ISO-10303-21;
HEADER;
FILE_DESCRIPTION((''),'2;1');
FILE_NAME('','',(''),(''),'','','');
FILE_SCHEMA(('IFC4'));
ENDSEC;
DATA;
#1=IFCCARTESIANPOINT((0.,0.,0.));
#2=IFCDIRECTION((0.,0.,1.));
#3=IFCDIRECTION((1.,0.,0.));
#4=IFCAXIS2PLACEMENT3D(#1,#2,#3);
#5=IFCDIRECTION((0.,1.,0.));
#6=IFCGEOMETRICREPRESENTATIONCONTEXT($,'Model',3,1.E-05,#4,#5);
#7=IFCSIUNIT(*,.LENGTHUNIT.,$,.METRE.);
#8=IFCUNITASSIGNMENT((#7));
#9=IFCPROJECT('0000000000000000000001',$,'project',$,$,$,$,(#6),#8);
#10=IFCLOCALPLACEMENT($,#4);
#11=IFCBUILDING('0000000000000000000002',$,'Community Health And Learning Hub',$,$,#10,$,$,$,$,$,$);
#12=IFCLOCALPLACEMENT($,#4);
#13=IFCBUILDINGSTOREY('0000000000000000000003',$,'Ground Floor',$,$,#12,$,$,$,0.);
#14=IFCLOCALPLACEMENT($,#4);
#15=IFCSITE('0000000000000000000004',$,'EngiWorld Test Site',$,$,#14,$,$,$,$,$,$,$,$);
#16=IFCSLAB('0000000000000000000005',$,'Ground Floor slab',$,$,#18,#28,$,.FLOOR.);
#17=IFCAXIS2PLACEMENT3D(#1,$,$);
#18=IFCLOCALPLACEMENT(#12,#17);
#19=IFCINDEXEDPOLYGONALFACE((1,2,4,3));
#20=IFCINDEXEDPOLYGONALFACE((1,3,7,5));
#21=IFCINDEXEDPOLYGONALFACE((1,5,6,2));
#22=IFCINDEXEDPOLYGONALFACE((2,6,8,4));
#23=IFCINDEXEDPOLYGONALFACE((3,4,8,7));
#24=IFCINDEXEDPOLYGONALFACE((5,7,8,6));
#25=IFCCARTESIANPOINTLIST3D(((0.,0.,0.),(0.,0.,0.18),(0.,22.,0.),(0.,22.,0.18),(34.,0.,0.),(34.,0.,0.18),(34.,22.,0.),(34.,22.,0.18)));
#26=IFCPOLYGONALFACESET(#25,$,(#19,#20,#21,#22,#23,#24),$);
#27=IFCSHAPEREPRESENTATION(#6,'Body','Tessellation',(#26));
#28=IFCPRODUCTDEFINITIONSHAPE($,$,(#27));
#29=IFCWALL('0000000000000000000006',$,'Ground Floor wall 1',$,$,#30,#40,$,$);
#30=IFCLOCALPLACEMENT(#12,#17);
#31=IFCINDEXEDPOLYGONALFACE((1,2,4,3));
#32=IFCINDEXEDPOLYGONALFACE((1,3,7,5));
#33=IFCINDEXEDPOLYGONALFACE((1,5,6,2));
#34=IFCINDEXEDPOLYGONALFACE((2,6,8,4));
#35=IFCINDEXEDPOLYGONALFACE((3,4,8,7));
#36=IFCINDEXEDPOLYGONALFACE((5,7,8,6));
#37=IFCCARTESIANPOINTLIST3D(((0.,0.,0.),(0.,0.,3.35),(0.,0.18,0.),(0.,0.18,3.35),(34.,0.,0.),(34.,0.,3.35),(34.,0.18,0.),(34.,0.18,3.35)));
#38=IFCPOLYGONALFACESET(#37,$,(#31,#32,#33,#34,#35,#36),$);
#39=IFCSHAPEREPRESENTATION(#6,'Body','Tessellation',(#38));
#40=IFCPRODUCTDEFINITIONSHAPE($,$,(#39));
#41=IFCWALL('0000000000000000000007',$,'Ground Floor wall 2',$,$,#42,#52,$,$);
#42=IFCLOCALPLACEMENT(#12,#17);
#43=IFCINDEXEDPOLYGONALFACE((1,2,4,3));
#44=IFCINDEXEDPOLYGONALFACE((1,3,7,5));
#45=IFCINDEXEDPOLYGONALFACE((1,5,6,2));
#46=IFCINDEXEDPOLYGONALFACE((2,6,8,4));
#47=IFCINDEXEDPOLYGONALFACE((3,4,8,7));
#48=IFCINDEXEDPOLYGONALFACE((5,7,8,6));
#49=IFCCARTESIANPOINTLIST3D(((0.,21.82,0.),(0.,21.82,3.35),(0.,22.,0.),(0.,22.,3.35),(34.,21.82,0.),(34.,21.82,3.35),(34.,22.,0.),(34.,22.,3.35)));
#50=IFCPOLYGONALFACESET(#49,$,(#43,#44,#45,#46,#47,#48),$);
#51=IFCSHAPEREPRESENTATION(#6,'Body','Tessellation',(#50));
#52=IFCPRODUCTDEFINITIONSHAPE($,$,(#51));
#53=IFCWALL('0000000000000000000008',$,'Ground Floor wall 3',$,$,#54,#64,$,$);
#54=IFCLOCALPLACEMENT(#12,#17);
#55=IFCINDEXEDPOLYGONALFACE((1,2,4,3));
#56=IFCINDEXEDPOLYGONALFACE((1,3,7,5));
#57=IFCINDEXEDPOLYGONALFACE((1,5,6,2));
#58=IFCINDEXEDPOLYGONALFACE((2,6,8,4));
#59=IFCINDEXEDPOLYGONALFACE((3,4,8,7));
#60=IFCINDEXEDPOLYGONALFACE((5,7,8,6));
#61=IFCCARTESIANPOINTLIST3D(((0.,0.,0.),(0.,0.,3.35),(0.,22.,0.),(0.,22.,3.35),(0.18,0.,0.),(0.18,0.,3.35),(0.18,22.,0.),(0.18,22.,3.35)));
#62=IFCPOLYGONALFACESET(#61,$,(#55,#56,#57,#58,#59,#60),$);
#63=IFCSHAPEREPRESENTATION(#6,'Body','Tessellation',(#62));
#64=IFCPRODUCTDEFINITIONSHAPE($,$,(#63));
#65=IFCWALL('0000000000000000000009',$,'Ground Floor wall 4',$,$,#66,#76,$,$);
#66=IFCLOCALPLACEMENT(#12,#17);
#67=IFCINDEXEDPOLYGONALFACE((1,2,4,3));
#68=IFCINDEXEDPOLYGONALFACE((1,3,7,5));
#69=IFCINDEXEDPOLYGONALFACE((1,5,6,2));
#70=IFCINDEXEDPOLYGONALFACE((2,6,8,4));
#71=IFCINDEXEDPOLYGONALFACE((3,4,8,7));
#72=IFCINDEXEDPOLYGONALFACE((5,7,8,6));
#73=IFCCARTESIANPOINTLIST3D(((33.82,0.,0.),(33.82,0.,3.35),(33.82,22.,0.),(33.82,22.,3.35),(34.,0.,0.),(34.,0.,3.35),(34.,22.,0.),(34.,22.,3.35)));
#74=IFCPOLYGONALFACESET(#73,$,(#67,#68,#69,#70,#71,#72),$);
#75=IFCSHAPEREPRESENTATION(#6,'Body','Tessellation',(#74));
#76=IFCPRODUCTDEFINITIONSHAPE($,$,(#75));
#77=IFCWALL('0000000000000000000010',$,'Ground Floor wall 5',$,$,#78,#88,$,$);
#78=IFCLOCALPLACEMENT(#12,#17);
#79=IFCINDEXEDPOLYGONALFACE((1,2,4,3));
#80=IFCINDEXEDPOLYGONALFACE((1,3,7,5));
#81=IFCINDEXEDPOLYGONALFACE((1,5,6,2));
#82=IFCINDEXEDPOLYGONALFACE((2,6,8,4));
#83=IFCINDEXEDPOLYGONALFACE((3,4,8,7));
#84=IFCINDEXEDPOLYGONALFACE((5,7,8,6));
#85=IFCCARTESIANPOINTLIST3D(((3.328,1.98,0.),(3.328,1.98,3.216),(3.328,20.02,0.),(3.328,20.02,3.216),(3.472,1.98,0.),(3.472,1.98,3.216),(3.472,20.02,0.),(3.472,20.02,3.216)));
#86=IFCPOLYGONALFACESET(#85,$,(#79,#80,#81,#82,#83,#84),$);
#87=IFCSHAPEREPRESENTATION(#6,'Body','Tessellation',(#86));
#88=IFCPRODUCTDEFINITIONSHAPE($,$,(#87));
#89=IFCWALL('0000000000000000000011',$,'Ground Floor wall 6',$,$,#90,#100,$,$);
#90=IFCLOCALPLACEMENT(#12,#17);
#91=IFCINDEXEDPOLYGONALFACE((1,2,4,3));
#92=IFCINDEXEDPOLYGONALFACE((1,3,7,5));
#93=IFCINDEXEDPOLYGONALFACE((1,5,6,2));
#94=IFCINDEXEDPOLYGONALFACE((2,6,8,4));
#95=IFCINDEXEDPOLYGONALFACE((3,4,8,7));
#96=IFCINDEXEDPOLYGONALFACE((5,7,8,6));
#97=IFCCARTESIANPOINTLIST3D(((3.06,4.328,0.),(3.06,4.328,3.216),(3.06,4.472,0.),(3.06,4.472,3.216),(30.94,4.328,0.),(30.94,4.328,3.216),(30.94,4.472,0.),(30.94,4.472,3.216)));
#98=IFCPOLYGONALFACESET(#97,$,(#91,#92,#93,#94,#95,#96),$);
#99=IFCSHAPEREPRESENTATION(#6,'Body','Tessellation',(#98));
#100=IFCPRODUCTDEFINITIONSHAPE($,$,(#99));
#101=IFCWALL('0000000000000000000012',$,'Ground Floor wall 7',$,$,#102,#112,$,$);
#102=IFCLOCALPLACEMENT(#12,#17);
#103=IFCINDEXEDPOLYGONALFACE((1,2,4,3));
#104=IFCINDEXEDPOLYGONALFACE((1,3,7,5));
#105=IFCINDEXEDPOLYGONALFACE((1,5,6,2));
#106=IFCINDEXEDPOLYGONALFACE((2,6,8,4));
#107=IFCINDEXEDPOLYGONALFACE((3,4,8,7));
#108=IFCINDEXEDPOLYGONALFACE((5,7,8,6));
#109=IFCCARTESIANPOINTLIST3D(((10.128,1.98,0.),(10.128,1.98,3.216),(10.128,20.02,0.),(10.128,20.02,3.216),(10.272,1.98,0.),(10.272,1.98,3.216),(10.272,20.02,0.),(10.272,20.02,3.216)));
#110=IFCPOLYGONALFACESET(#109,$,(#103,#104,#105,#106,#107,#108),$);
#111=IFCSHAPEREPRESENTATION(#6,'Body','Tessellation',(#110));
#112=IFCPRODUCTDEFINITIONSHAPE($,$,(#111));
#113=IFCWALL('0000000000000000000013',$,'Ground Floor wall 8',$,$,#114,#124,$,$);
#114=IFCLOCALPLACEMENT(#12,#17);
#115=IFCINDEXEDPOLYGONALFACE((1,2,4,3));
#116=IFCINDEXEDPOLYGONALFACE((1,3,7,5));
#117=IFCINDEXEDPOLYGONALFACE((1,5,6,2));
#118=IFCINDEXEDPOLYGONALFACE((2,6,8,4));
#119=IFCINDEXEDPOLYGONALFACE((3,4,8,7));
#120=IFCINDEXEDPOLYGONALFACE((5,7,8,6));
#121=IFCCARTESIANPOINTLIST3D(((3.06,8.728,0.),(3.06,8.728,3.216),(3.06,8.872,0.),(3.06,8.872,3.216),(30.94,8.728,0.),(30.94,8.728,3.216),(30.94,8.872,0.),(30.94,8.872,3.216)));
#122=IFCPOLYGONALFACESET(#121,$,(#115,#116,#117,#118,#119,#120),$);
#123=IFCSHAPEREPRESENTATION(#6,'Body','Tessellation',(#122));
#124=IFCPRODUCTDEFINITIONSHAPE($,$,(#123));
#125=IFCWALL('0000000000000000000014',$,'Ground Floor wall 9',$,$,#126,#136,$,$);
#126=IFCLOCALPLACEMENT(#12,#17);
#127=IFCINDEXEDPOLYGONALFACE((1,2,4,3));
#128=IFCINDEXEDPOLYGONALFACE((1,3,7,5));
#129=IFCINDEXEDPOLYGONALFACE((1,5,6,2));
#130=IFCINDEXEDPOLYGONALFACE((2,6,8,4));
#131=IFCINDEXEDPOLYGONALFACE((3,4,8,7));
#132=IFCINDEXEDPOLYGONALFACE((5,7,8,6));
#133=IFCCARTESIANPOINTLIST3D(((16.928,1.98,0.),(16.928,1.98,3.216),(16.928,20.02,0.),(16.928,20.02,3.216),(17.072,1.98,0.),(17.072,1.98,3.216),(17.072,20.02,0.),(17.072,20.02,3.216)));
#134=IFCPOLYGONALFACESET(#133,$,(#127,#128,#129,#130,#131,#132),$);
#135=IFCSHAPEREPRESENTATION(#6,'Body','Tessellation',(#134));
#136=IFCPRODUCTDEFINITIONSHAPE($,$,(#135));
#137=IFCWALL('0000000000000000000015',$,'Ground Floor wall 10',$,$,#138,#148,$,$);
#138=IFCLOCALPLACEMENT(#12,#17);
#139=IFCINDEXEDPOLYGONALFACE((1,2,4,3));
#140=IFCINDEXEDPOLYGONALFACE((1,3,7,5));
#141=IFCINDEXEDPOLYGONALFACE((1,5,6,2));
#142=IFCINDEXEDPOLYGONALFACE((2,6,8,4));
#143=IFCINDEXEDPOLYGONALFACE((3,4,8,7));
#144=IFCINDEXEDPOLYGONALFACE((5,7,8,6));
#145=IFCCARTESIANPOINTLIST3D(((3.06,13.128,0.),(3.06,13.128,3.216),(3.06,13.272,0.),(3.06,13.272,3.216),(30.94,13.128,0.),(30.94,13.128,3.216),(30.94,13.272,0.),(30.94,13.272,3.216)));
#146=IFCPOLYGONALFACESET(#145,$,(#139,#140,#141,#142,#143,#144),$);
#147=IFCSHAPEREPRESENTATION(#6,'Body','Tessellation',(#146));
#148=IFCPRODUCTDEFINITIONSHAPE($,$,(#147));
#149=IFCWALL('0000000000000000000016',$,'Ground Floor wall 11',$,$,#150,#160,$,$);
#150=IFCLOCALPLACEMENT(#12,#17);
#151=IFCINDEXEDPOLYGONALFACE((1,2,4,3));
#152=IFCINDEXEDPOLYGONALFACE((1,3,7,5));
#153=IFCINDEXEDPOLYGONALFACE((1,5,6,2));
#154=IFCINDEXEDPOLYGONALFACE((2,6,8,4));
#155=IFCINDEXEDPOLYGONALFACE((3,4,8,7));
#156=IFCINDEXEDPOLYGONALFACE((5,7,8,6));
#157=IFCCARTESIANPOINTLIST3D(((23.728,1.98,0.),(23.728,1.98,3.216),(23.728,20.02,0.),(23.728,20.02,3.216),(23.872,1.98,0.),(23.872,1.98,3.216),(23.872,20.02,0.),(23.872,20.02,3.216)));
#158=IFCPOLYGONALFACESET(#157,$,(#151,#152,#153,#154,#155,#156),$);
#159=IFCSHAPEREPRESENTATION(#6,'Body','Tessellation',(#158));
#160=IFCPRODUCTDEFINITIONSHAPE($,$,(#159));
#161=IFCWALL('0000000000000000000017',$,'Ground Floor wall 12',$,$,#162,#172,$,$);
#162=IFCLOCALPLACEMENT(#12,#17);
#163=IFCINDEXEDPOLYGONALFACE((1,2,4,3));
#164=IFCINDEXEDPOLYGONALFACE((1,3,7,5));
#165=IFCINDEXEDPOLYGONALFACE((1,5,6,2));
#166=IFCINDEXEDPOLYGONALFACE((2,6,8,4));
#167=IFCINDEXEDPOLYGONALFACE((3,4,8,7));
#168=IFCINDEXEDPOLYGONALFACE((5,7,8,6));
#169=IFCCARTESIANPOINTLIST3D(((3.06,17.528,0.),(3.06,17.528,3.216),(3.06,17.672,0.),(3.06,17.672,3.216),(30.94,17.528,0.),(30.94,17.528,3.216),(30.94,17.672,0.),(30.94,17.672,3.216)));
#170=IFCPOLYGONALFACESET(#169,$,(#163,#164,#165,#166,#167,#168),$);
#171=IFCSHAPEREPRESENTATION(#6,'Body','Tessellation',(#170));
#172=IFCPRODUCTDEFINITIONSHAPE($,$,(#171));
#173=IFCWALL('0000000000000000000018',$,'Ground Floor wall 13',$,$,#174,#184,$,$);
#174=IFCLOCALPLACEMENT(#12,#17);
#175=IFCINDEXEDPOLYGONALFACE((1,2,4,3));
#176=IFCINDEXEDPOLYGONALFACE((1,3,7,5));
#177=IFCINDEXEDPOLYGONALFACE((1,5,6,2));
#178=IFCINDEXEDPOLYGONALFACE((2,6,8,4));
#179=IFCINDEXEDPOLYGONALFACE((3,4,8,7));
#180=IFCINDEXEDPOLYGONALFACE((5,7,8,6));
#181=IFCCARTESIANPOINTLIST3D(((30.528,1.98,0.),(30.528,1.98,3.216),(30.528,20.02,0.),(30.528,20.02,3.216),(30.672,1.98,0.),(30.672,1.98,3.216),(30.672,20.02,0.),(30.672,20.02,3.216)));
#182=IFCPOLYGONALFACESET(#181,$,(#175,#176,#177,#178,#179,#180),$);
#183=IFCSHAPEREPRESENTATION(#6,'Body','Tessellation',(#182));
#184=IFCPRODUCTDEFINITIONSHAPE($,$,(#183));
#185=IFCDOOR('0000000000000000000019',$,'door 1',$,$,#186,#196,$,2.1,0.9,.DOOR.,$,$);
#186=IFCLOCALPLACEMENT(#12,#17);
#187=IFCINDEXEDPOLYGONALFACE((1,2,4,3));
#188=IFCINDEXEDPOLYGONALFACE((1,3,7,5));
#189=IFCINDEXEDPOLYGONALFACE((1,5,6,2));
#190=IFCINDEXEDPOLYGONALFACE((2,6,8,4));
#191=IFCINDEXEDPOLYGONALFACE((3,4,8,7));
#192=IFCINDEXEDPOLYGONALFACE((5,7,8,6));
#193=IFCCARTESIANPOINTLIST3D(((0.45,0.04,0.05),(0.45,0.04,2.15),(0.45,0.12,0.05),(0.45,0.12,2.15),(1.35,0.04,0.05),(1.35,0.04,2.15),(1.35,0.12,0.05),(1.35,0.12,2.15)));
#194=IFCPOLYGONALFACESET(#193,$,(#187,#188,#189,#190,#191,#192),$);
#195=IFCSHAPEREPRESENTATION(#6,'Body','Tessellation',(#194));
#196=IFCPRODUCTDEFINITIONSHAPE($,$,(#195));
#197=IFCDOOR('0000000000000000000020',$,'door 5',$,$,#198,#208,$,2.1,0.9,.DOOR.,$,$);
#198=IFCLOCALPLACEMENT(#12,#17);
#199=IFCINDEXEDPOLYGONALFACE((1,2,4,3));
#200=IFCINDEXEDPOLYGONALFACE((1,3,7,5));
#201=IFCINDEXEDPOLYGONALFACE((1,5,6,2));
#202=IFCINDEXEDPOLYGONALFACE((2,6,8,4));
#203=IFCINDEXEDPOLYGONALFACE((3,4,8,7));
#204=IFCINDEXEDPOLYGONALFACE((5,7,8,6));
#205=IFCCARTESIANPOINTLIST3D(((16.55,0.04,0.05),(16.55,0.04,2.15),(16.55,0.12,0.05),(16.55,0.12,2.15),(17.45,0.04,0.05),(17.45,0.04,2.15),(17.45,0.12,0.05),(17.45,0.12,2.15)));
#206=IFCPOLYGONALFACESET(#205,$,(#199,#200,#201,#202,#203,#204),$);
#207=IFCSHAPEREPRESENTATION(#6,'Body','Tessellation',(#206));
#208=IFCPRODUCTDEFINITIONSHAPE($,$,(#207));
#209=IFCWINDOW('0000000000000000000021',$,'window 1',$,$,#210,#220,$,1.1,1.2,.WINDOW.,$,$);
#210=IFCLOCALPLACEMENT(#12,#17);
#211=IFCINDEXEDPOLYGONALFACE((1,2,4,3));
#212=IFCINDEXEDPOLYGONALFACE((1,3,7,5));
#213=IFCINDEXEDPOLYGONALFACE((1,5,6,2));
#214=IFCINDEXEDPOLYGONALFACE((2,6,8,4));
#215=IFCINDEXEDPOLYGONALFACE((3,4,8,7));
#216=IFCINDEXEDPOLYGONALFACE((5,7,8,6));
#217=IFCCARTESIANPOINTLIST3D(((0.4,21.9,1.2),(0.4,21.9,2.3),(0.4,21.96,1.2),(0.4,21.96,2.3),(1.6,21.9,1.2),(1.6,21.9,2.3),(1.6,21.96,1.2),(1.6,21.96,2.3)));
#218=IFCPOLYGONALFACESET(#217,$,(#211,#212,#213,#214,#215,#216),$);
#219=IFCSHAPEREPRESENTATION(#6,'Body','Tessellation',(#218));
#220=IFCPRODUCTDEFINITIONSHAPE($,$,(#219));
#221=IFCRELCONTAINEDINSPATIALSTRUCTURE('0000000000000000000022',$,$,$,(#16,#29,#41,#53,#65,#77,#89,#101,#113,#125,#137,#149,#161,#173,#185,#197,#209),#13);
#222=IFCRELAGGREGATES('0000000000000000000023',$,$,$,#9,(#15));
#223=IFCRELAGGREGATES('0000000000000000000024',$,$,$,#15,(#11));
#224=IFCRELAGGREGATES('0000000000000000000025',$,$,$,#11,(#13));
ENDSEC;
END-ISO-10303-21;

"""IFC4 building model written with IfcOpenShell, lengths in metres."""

from ifc_helpers import new_model, si_unit, direction, frame, origin_with_axes, origin_2d_with_axis, place, context, project, spatial, rectangle, extrude, element, save


model = new_model("IFC4")

# Units and contexts
model_context = context("Model", 3, precision=1e-05, world=origin_with_axes(), true_north=direction((0.0, 1.0, 0.0)))
ifc_project = project(units=[si_unit("LENGTHUNIT", "METRE")], contexts=[model_context])

# Site, building, storey
site_placement = place(None, origin_with_axes())
site = spatial("IfcSite", under=ifc_project, at=site_placement, Name="EngiWorld Test Site")
building_placement = place(None, origin_with_axes())
building = spatial("IfcBuilding", under=site, at=building_placement, Name="Community Health And Learning Hub")
storey_placement = place(None, origin_with_axes())
storey = spatial("IfcBuildingStorey", under=building, at=storey_placement, Name="Ground Floor", Elevation=0.0)

# Slab
slab_placement = place(None, frame((17.0, 11.0, 0.0), z_axis=(0.0, 0.0, 1.0), x_axis=(1.0, 0.0, 0.0)))
element("IfcSlab", 1, at=slab_placement, inside=storey, Name="Ground Floor slab", PredefinedType="FLOOR", context=model_context, shape_type="SweptSolid", body=[
    extrude(rectangle(XDim=34.0, YDim=22.0, at=origin_2d_with_axis()), origin_with_axes(), (0.0, 0.0, 1.0), 0.18),
])

# Walls
for number, where, z_axis, x_axis, name in (
    (2, (17.0, 0.09, 0.0), (0.0, 0.0, 1.0), (1.0, 0.0, 0.0), "Ground Floor wall 1"),
    (3, (17.0, 21.91, 0.0), (0.0, 0.0, 1.0), (1.0, 0.0, 0.0), "Ground Floor wall 2"),
):
    element("IfcWall", number, at=place(None, frame(where, z_axis=z_axis, x_axis=x_axis)), inside=storey, Name=name, context=model_context, shape_type="SweptSolid", body=[
        extrude(rectangle(XDim=34.0, YDim=0.18, at=origin_2d_with_axis()), origin_with_axes(), (0.0, 0.0, 1.0), 3.35),
    ])
for number, where, z_axis, x_axis, name in (
    (4, (0.09, 11.0, 0.0), (0.0, 0.0, 1.0), (1.0, 0.0, 0.0), "Ground Floor wall 3"),
    (5, (33.91, 11.0, 0.0), (0.0, 0.0, 1.0), (1.0, 0.0, 0.0), "Ground Floor wall 4"),
):
    element("IfcWall", number, at=place(None, frame(where, z_axis=z_axis, x_axis=x_axis)), inside=storey, Name=name, context=model_context, shape_type="SweptSolid", body=[
        extrude(rectangle(XDim=0.18, YDim=22.0, at=origin_2d_with_axis()), origin_with_axes(), (0.0, 0.0, 1.0), 3.35),
    ])
wall_1_placement = place(None, frame((3.4, 11.0, 0.0), z_axis=(0.0, 0.0, 1.0), x_axis=(1.0, 0.0, 0.0)))
element("IfcWall", 6, at=wall_1_placement, inside=storey, Name="Ground Floor wall 5", context=model_context, shape_type="SweptSolid", body=[
    extrude(rectangle(XDim=0.144, YDim=18.04, at=origin_2d_with_axis()), origin_with_axes(), (0.0, 0.0, 1.0), 3.216),
])
wall_2_placement = place(None, frame((17.0, 4.4, 0.0), z_axis=(0.0, 0.0, 1.0), x_axis=(1.0, 0.0, 0.0)))
element("IfcWall", 7, at=wall_2_placement, inside=storey, Name="Ground Floor wall 6", context=model_context, shape_type="SweptSolid", body=[
    extrude(rectangle(XDim=27.88, YDim=0.144, at=origin_2d_with_axis()), origin_with_axes(), (0.0, 0.0, 1.0), 3.216),
])
wall_3_placement = place(None, frame((10.2, 11.0, 0.0), z_axis=(0.0, 0.0, 1.0), x_axis=(1.0, 0.0, 0.0)))
element("IfcWall", 8, at=wall_3_placement, inside=storey, Name="Ground Floor wall 7", context=model_context, shape_type="SweptSolid", body=[
    extrude(rectangle(XDim=0.144, YDim=18.04, at=origin_2d_with_axis()), origin_with_axes(), (0.0, 0.0, 1.0), 3.216),
])
wall_4_placement = place(None, frame((17.0, 8.8, 0.0), z_axis=(0.0, 0.0, 1.0), x_axis=(1.0, 0.0, 0.0)))
element("IfcWall", 9, at=wall_4_placement, inside=storey, Name="Ground Floor wall 8", context=model_context, shape_type="SweptSolid", body=[
    extrude(rectangle(XDim=27.88, YDim=0.144, at=origin_2d_with_axis()), origin_with_axes(), (0.0, 0.0, 1.0), 3.216),
])
wall_5_placement = place(None, frame((17.0, 11.0, 0.0), z_axis=(0.0, 0.0, 1.0), x_axis=(1.0, 0.0, 0.0)))
element("IfcWall", 10, at=wall_5_placement, inside=storey, Name="Ground Floor wall 9", context=model_context, shape_type="SweptSolid", body=[
    extrude(rectangle(XDim=0.144, YDim=18.04, at=origin_2d_with_axis()), origin_with_axes(), (0.0, 0.0, 1.0), 3.216),
])
wall_6_placement = place(None, frame((17.0, 13.2, 0.0), z_axis=(0.0, 0.0, 1.0), x_axis=(1.0, 0.0, 0.0)))
element("IfcWall", 11, at=wall_6_placement, inside=storey, Name="Ground Floor wall 10", context=model_context, shape_type="SweptSolid", body=[
    extrude(rectangle(XDim=27.88, YDim=0.144, at=origin_2d_with_axis()), origin_with_axes(), (0.0, 0.0, 1.0), 3.216),
])
wall_7_placement = place(None, frame((23.8, 11.0, 0.0), z_axis=(0.0, 0.0, 1.0), x_axis=(1.0, 0.0, 0.0)))
element("IfcWall", 12, at=wall_7_placement, inside=storey, Name="Ground Floor wall 11", context=model_context, shape_type="SweptSolid", body=[
    extrude(rectangle(XDim=0.144, YDim=18.04, at=origin_2d_with_axis()), origin_with_axes(), (0.0, 0.0, 1.0), 3.216),
])
wall_8_placement = place(None, frame((17.0, 17.6, 0.0), z_axis=(0.0, 0.0, 1.0), x_axis=(1.0, 0.0, 0.0)))
element("IfcWall", 13, at=wall_8_placement, inside=storey, Name="Ground Floor wall 12", context=model_context, shape_type="SweptSolid", body=[
    extrude(rectangle(XDim=27.88, YDim=0.144, at=origin_2d_with_axis()), origin_with_axes(), (0.0, 0.0, 1.0), 3.216),
])
wall_9_placement = place(None, frame((30.6, 11.0, 0.0), z_axis=(0.0, 0.0, 1.0), x_axis=(1.0, 0.0, 0.0)))
element("IfcWall", 14, at=wall_9_placement, inside=storey, Name="Ground Floor wall 13", context=model_context, shape_type="SweptSolid", body=[
    extrude(rectangle(XDim=0.144, YDim=18.04, at=origin_2d_with_axis()), origin_with_axes(), (0.0, 0.0, 1.0), 3.216),
])

# Doors
for number, where, z_axis, x_axis, name in (
    (15, (0.9, 0.08, 0.05), (0.0, 0.0, 1.0), (1.0, 0.0, 0.0), "door 1"),
    (16, (17.0, 0.08, 0.05), (0.0, 0.0, 1.0), (1.0, 0.0, 0.0), "door 5"),
):
    element("IfcDoor", number, at=place(None, frame(where, z_axis=z_axis, x_axis=x_axis)), inside=storey, Name=name, OverallHeight=2.1, OverallWidth=0.9, PredefinedType="DOOR", context=model_context, shape_type="SweptSolid", body=[
        extrude(rectangle(XDim=0.9, YDim=0.08, at=origin_2d_with_axis()), origin_with_axes(), (0.0, 0.0, 1.0), 2.1),
    ])

# Window
for number, where, z_axis, x_axis, name in (
    (17, (1.0, 21.93, 1.2), (0.0, 0.0, 1.0), (1.0, 0.0, 0.0), "window 1"),
):
    element("IfcWindow", number, at=place(None, frame(where, z_axis=z_axis, x_axis=x_axis)), inside=storey, Name=name, OverallHeight=1.1, OverallWidth=1.2, PredefinedType="WINDOW", context=model_context, shape_type="SweptSolid", body=[
        extrude(rectangle(XDim=1.2, YDim=0.06, at=origin_2d_with_axis()), origin_with_axes(), (0.0, 0.0, 1.0), 1.1),
    ])

save(model, "model.ifc")
